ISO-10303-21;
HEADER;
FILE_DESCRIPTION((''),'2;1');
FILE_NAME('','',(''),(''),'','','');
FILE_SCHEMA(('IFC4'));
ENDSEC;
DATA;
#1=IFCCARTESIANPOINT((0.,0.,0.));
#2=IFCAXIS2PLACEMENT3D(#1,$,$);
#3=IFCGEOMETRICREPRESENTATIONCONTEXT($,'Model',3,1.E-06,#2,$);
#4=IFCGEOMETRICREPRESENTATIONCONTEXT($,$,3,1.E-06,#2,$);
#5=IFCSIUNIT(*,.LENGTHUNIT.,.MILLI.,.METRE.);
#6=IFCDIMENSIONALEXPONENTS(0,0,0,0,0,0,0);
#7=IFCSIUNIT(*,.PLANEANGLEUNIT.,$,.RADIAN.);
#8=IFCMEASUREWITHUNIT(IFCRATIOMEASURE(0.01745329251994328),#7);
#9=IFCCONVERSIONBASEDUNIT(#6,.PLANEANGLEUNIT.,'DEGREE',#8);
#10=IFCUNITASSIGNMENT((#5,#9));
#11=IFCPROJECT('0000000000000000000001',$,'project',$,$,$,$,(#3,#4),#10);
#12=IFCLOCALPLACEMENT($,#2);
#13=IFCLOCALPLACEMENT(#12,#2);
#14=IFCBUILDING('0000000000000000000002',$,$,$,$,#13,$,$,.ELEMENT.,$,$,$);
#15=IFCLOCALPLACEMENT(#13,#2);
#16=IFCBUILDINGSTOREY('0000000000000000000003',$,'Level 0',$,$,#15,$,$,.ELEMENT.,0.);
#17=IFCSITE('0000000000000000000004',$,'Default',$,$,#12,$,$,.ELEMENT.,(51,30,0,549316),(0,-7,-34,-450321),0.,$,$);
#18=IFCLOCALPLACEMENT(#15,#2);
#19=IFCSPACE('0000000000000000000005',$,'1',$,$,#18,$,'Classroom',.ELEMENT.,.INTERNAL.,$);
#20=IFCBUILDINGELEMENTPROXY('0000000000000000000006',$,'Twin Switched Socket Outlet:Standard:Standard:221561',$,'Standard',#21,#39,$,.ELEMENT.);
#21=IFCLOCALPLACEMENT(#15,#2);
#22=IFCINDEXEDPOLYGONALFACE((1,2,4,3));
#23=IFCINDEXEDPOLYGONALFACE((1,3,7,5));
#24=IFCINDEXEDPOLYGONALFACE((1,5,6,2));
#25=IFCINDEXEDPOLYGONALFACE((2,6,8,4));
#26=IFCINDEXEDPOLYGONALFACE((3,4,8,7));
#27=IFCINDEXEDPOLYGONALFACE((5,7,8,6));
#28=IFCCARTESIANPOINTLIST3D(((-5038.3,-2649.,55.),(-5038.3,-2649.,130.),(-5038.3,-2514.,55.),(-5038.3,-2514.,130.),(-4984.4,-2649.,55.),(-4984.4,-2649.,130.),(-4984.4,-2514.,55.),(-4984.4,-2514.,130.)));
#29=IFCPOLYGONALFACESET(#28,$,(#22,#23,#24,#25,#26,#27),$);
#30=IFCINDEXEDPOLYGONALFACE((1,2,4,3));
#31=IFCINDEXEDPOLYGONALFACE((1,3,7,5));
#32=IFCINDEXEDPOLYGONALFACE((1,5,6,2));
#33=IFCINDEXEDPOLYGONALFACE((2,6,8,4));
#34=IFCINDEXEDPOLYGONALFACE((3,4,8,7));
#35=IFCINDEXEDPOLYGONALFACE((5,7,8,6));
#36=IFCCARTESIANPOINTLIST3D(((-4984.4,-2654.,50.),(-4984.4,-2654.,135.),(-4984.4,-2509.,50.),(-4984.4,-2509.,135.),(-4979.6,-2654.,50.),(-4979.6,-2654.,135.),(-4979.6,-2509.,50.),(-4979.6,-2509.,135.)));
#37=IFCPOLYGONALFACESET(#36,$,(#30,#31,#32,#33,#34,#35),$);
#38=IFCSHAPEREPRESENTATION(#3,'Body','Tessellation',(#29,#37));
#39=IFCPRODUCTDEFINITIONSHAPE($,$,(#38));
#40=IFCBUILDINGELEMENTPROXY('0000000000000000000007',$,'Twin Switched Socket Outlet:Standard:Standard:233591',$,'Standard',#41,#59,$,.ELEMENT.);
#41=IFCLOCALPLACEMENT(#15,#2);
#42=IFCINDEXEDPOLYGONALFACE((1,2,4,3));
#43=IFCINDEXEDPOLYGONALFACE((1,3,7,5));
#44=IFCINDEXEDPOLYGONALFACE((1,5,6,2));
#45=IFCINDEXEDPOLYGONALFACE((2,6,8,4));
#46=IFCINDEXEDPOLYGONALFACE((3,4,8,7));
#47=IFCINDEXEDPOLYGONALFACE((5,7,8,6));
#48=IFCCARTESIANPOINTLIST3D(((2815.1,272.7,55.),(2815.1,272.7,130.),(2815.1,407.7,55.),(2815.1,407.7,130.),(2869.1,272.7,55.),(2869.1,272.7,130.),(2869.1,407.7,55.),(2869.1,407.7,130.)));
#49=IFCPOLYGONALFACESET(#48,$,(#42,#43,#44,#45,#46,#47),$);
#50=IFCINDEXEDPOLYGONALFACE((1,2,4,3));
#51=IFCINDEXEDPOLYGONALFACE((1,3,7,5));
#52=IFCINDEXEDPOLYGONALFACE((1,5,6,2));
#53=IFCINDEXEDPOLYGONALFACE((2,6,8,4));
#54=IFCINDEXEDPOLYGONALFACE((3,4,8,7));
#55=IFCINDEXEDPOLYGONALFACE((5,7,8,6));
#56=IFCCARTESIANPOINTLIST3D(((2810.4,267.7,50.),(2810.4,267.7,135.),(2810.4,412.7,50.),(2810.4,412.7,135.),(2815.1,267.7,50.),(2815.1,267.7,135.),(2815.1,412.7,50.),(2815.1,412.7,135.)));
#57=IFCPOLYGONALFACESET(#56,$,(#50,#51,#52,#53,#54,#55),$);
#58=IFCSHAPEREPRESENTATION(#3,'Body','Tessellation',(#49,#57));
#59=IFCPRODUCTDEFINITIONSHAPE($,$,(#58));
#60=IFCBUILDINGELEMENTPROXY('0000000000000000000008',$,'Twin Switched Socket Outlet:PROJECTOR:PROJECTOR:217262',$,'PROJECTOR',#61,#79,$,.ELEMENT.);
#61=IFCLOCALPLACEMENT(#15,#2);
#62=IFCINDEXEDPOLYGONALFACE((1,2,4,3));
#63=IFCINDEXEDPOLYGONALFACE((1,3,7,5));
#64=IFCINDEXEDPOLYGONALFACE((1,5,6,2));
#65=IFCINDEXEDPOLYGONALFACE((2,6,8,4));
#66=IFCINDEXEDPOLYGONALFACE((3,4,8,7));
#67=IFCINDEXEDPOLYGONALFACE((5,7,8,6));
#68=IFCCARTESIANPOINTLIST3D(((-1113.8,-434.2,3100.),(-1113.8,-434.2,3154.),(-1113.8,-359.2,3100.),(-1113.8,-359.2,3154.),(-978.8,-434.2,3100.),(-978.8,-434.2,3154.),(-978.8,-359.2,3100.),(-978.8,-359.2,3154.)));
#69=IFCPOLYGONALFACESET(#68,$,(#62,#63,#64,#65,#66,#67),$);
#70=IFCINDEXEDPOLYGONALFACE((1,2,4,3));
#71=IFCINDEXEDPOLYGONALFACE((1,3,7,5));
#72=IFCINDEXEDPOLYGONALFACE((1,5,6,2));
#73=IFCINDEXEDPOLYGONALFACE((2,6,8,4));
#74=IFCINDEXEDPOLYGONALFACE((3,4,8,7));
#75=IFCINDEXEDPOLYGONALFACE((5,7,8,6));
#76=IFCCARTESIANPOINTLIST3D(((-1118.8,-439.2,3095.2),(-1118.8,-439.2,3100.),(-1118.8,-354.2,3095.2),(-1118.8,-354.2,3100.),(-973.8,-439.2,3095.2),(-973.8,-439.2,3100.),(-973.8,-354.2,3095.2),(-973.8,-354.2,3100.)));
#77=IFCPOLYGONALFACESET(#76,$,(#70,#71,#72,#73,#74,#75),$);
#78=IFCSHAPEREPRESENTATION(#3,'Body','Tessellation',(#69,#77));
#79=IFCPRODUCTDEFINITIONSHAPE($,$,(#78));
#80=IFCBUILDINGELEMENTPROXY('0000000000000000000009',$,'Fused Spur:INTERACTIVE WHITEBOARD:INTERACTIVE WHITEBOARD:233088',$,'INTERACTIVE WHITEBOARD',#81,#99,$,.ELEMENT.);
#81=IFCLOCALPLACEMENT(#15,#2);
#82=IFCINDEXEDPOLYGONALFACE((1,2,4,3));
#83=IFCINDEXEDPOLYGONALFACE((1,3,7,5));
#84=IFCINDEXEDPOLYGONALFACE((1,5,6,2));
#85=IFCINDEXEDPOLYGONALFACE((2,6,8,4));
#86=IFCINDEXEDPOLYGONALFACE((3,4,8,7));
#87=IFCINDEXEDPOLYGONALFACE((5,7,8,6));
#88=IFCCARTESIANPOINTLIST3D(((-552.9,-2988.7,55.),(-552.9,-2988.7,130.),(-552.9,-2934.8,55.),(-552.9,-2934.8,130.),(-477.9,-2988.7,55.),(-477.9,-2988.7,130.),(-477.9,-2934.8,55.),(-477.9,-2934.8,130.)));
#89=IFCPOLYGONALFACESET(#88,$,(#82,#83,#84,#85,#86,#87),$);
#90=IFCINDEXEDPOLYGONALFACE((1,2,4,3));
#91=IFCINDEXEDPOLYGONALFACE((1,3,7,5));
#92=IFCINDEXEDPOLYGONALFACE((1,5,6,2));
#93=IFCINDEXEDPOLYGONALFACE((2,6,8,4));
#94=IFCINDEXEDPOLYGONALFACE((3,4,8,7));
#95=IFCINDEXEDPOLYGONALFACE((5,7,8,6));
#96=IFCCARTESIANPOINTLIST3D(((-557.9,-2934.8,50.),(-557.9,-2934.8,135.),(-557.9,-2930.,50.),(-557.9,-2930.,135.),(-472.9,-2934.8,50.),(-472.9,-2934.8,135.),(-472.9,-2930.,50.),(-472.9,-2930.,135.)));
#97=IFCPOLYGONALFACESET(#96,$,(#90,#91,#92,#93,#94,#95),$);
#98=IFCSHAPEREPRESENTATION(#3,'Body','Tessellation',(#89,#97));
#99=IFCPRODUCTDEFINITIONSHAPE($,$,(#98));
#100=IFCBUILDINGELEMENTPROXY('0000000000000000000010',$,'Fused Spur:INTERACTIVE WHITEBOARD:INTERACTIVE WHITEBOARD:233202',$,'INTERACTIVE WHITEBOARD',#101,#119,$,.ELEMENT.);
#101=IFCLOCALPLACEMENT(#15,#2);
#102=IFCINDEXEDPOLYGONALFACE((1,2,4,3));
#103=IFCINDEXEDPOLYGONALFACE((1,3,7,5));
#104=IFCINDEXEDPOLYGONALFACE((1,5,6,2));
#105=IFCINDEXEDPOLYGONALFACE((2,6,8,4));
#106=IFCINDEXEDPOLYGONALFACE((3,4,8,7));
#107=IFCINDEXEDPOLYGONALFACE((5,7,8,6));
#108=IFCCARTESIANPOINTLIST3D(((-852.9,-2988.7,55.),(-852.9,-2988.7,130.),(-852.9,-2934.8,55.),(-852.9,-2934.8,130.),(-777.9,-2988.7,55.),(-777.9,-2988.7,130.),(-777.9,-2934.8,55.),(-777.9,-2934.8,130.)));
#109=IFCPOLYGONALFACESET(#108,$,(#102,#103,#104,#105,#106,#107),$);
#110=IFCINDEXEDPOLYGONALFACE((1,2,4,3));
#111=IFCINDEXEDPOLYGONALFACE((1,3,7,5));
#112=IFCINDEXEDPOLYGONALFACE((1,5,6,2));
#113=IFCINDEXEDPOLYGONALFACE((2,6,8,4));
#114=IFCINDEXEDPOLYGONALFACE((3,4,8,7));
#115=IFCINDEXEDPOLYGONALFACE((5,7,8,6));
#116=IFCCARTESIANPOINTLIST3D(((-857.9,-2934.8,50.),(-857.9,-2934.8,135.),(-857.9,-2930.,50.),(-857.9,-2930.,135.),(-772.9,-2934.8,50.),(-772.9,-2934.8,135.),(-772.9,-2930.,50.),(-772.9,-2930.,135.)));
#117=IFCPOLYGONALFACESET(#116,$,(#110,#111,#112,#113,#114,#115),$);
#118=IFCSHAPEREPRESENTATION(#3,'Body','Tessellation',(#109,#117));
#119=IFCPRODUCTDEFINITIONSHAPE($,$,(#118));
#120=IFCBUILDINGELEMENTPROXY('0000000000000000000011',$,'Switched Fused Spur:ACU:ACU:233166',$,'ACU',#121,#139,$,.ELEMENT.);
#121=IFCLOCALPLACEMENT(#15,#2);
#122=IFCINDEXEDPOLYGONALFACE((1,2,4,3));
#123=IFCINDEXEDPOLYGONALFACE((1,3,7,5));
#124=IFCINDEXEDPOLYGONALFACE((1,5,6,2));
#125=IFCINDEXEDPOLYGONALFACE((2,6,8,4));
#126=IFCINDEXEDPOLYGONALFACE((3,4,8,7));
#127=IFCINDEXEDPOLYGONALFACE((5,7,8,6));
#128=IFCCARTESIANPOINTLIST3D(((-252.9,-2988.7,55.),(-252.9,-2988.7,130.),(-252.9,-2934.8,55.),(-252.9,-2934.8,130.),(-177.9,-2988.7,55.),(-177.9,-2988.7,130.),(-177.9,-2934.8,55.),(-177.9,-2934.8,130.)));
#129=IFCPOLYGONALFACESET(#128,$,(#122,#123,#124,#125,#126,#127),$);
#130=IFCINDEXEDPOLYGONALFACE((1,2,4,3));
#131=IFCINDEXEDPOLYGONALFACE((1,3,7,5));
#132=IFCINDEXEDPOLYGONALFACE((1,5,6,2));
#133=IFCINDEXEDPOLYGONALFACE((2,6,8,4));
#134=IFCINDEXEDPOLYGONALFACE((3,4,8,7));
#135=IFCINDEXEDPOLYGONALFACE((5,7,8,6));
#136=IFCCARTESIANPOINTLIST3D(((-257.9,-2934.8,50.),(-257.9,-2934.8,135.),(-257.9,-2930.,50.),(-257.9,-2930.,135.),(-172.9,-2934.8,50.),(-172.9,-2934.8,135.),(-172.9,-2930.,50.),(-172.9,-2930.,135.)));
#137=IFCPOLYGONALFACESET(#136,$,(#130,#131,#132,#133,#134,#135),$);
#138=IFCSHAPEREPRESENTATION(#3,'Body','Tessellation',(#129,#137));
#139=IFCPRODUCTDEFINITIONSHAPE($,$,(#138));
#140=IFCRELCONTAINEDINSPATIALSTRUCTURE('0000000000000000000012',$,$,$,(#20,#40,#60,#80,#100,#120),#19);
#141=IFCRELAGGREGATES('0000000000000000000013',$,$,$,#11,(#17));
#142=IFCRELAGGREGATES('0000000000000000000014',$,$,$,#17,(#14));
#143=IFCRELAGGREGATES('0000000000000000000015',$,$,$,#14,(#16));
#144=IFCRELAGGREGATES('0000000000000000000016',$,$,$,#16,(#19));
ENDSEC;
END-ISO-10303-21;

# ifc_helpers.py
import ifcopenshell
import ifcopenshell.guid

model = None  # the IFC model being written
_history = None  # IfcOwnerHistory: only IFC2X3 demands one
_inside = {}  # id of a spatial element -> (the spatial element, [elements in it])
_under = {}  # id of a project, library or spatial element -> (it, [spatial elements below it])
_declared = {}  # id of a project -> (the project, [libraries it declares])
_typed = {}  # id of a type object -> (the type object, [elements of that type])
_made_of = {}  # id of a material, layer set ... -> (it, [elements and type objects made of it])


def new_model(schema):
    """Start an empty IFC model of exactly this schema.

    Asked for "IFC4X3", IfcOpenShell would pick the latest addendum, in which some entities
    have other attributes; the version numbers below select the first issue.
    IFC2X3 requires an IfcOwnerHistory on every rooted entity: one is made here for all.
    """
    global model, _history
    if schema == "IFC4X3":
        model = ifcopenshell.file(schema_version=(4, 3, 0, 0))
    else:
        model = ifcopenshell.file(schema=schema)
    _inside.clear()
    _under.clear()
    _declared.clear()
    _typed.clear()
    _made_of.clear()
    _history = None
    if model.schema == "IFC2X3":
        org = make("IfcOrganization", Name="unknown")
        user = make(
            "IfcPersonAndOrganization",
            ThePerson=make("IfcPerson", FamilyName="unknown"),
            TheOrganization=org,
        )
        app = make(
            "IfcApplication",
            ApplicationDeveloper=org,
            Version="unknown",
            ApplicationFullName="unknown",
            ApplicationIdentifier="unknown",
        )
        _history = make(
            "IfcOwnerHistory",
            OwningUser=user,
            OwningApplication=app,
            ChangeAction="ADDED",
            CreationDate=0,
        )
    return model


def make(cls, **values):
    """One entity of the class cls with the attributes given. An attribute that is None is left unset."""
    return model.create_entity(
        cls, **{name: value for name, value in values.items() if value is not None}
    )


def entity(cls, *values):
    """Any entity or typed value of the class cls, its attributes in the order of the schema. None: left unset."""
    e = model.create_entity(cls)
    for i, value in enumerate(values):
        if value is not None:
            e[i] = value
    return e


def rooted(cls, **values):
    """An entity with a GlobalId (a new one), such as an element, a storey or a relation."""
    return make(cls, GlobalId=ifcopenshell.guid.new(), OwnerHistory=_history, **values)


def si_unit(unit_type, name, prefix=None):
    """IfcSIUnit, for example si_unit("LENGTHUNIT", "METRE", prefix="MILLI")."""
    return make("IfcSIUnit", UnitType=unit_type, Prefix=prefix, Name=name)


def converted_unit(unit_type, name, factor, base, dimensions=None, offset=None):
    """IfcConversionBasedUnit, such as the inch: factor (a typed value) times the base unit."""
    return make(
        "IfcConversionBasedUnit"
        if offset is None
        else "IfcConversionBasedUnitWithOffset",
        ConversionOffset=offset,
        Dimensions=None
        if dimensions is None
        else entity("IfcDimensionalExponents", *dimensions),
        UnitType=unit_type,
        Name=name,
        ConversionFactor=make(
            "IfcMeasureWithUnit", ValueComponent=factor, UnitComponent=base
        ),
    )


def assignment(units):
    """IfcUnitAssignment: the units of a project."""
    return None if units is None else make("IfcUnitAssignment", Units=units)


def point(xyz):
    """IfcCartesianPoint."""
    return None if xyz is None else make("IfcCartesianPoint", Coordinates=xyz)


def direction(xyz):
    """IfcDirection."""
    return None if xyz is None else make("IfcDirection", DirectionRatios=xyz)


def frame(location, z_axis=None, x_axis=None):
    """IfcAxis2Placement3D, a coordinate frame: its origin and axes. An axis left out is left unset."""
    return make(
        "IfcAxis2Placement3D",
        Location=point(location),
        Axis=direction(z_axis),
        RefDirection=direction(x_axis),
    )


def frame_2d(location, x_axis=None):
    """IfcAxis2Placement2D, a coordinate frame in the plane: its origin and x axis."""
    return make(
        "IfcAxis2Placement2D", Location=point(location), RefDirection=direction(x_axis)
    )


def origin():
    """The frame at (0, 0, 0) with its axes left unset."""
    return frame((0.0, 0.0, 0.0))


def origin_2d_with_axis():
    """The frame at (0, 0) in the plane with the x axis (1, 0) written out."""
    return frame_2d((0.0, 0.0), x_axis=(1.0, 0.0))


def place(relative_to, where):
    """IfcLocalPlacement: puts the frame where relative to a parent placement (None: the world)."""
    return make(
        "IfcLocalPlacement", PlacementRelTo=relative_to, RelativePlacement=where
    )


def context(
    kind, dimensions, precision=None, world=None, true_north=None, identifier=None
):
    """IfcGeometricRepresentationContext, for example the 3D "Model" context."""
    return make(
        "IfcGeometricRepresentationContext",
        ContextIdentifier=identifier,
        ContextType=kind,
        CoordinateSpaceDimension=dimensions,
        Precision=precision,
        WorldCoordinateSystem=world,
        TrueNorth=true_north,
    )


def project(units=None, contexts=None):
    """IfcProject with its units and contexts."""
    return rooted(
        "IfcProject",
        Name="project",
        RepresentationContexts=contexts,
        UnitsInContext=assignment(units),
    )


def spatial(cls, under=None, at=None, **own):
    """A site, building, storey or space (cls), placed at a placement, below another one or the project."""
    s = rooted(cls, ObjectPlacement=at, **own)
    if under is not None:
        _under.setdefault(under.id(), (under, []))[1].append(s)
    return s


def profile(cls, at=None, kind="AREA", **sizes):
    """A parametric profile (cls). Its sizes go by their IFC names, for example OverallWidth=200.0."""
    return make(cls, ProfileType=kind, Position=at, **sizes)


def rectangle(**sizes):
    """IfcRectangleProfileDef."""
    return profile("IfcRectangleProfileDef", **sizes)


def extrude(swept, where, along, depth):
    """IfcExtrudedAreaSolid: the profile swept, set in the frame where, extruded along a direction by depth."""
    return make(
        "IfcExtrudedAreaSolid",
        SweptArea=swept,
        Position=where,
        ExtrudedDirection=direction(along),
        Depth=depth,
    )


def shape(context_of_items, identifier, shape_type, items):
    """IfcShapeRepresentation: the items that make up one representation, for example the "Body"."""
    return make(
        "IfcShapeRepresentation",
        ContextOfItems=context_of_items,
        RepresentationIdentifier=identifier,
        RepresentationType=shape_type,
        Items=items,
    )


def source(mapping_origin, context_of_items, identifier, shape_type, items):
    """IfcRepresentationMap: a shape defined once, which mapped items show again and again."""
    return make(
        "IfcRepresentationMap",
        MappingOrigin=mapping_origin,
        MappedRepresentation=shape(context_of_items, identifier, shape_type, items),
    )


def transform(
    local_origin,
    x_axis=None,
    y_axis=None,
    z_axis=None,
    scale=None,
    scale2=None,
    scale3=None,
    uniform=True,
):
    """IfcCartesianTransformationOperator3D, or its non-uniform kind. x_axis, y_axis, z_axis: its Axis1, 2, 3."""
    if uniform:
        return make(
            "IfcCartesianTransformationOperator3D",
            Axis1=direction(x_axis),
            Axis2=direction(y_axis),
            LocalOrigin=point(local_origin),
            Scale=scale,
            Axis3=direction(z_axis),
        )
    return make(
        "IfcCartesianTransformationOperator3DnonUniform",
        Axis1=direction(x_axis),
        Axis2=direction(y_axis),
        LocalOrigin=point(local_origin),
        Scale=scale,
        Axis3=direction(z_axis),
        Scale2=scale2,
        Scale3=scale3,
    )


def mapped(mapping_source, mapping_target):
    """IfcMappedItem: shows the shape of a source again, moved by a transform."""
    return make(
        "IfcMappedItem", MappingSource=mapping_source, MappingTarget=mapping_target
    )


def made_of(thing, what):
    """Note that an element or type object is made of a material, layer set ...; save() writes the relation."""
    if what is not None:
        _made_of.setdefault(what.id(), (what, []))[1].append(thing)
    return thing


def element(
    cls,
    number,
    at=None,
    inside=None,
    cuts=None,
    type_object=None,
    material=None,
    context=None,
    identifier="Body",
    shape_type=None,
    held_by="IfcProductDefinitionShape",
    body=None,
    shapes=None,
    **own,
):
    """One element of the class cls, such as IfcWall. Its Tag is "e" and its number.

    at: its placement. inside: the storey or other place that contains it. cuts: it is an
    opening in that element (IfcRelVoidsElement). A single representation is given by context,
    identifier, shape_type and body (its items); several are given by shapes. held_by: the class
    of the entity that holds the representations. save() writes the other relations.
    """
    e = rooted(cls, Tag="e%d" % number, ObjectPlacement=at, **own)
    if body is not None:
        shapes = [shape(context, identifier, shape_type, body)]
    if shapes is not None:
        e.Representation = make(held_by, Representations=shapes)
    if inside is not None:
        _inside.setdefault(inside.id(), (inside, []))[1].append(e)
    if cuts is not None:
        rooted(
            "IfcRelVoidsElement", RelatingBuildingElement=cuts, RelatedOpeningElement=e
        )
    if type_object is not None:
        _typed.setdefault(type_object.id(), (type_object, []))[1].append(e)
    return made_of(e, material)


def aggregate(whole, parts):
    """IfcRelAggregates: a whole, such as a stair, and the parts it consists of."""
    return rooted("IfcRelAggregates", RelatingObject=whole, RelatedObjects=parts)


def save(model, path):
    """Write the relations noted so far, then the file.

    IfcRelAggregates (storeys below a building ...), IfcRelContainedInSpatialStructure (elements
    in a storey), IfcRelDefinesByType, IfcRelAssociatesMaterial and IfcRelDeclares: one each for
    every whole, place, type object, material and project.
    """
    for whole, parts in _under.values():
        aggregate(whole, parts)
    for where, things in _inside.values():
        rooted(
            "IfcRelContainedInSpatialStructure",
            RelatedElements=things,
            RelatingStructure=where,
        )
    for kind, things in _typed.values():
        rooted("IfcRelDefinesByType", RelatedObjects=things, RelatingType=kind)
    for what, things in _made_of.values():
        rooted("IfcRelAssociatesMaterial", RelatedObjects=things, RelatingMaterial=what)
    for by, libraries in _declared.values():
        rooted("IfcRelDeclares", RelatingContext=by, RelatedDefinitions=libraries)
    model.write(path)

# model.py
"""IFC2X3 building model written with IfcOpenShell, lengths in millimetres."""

from ifc_helpers import new_model, entity, si_unit, converted_unit, frame, origin, origin_2d_with_axis, place, context, project, spatial, rectangle, extrude, source, transform, mapped, element, save


model = new_model("IFC2X3")

# Units and contexts
model_context = context("Model", 3, precision=1e-06, world=origin())
context_of_model = context(None, 3, precision=1e-06, world=origin())
ifc_project = project(units=[si_unit("LENGTHUNIT", "METRE", prefix="MILLI"), converted_unit("PLANEANGLEUNIT", "DEGREE", entity("IfcRatioMeasure", 0.01745329251994328), si_unit("PLANEANGLEUNIT", "RADIAN"), dimensions=[0, 0, 0, 0, 0, 0, 0])], contexts=[model_context, context_of_model])

# Site, building, storey
site_placement = place(None, origin())
site = spatial("IfcSite", under=ifc_project, at=site_placement, Name="Default", CompositionType="ELEMENT", RefLatitude=(51, 30, 0, 549316), RefLongitude=(0, -7, -34, -450321), RefElevation=0.0)
building_placement = place(site_placement, origin())
building = spatial("IfcBuilding", under=site, at=building_placement, CompositionType="ELEMENT")
storey_placement = place(building_placement, origin())
storey = spatial("IfcBuildingStorey", under=building, at=storey_placement, Name="Level 0", CompositionType="ELEMENT", Elevation=0.0)

# Shared definitions
space_placement = place(storey_placement, origin())
space = spatial("IfcSpace", under=storey, at=space_placement, Name="1", LongName="Classroom", CompositionType="ELEMENT", InteriorOrExteriorSpace="INTERNAL")

# Building element proxies
shared_shape_1 = source(origin(), model_context, "Body", "SweptSolid", [
    extrude(rectangle(XDim=135.0, YDim=75.0, at=origin_2d_with_axis()), frame((0.0, 0.0, -54.0), z_axis=(0.0, 0.0, 1.0), x_axis=(-1.0, 0.0, 0.0)), (0.0, 0.0, 1.0), 54.0),
    extrude(rectangle(XDim=145.0, YDim=85.0, at=origin_2d_with_axis()), frame((0.0, 0.0, 0.0), z_axis=(0.0, 0.0, 1.0), x_axis=(-1.0, 0.0, 0.0)), (0.0, 0.0, 1.0), 4.8),
])
for number, where, z_axis, x_axis, name in (
    (1, (-4984.4, -2581.5, 92.5), (1.0, 0.0, 0.0), (0.0, 1.0, 0.0), "Twin Switched Socket Outlet:Standard:Standard:221561"),
    (2, (2815.1, 340.2, 92.5), (-1.0, 0.0, 0.0), (0.0, -1.0, 0.0), "Twin Switched Socket Outlet:Standard:Standard:233591"),
):
    element("IfcBuildingElementProxy", number, at=place(space_placement, frame(where, z_axis=z_axis, x_axis=x_axis)), inside=space, Name=name, ObjectType="Standard", CompositionType="ELEMENT", context=model_context, shape_type="MappedRepresentation", body=[
        mapped(shared_shape_1, transform((0.0, 0.0, 0.0), scale=1.0)),
    ])
shared_shape_2 = source(origin(), model_context, "Body", "SweptSolid", [
    extrude(rectangle(XDim=135.0, YDim=75.0, at=origin_2d_with_axis()), frame((0.0, 0.0, -54.0), z_axis=(0.0, 0.0, 1.0), x_axis=(-1.0, 0.0, 0.0)), (0.0, 0.0, 1.0), 54.0),
    extrude(rectangle(XDim=145.0, YDim=85.0, at=origin_2d_with_axis()), frame((0.0, 0.0, 0.0), z_axis=(0.0, 0.0, 1.0), x_axis=(-1.0, 0.0, 0.0)), (0.0, 0.0, 1.0), 4.8),
])
proxy_1_placement = place(space_placement, frame((-1046.3, -396.7, 3100.0), z_axis=(0.0, 0.0, -1.0), x_axis=(1.0, 0.0, 0.0)))
element("IfcBuildingElementProxy", 3, at=proxy_1_placement, inside=space, Name="Twin Switched Socket Outlet:PROJECTOR:PROJECTOR:217262", ObjectType="PROJECTOR", CompositionType="ELEMENT", context=model_context, shape_type="MappedRepresentation", body=[
    mapped(shared_shape_2, transform((0.0, 0.0, 0.0), scale=1.0)),
])
shared_shape_3 = source(origin(), model_context, "Body", "SweptSolid", [
    extrude(rectangle(XDim=75.0, YDim=75.0, at=origin_2d_with_axis()), frame((0.0, 0.0, -54.0), z_axis=(0.0, 0.0, 1.0), x_axis=(-1.0, 0.0, 0.0)), (0.0, 0.0, 1.0), 54.0),
    extrude(rectangle(XDim=85.0, YDim=85.0, at=origin_2d_with_axis()), frame((0.0, 0.0, 0.0), z_axis=(0.0, 0.0, 1.0), x_axis=(-1.0, 0.0, 0.0)), (0.0, 0.0, 1.0), 4.8),
])
for number, where, z_axis, x_axis, name in (
    (4, (-515.4, -2934.8, 92.5), (0.0, 1.0, 0.0), (-1.0, 0.0, 0.0), "Fused Spur:INTERACTIVE WHITEBOARD:INTERACTIVE WHITEBOARD:233088"),
    (5, (-815.4, -2934.8, 92.5), (0.0, 1.0, 0.0), (-1.0, 0.0, 0.0), "Fused Spur:INTERACTIVE WHITEBOARD:INTERACTIVE WHITEBOARD:233202"),
):
    element("IfcBuildingElementProxy", number, at=place(space_placement, frame(where, z_axis=z_axis, x_axis=x_axis)), inside=space, Name=name, ObjectType="INTERACTIVE WHITEBOARD", CompositionType="ELEMENT", context=model_context, shape_type="MappedRepresentation", body=[
        mapped(shared_shape_3, transform((0.0, 0.0, 0.0), scale=1.0)),
    ])
shared_shape_4 = source(origin(), model_context, "Body", "SweptSolid", [
    extrude(rectangle(XDim=75.0, YDim=75.0, at=origin_2d_with_axis()), frame((0.0, 0.0, -54.0), z_axis=(0.0, 0.0, 1.0), x_axis=(-1.0, 0.0, 0.0)), (0.0, 0.0, 1.0), 54.0),
    extrude(rectangle(XDim=85.0, YDim=85.0, at=origin_2d_with_axis()), frame((0.0, 0.0, 0.0), z_axis=(0.0, 0.0, 1.0), x_axis=(-1.0, 0.0, 0.0)), (0.0, 0.0, 1.0), 4.8),
])
proxy_2_placement = place(space_placement, frame((-215.4, -2934.8, 92.5), z_axis=(0.0, 1.0, 0.0), x_axis=(-1.0, 0.0, 0.0)))
element("IfcBuildingElementProxy", 6, at=proxy_2_placement, inside=space, Name="Switched Fused Spur:ACU:ACU:233166", ObjectType="ACU", CompositionType="ELEMENT", context=model_context, shape_type="MappedRepresentation", body=[
    mapped(shared_shape_4, transform((0.0, 0.0, 0.0), scale=1.0)),
])

save(model, "model.ifc")
